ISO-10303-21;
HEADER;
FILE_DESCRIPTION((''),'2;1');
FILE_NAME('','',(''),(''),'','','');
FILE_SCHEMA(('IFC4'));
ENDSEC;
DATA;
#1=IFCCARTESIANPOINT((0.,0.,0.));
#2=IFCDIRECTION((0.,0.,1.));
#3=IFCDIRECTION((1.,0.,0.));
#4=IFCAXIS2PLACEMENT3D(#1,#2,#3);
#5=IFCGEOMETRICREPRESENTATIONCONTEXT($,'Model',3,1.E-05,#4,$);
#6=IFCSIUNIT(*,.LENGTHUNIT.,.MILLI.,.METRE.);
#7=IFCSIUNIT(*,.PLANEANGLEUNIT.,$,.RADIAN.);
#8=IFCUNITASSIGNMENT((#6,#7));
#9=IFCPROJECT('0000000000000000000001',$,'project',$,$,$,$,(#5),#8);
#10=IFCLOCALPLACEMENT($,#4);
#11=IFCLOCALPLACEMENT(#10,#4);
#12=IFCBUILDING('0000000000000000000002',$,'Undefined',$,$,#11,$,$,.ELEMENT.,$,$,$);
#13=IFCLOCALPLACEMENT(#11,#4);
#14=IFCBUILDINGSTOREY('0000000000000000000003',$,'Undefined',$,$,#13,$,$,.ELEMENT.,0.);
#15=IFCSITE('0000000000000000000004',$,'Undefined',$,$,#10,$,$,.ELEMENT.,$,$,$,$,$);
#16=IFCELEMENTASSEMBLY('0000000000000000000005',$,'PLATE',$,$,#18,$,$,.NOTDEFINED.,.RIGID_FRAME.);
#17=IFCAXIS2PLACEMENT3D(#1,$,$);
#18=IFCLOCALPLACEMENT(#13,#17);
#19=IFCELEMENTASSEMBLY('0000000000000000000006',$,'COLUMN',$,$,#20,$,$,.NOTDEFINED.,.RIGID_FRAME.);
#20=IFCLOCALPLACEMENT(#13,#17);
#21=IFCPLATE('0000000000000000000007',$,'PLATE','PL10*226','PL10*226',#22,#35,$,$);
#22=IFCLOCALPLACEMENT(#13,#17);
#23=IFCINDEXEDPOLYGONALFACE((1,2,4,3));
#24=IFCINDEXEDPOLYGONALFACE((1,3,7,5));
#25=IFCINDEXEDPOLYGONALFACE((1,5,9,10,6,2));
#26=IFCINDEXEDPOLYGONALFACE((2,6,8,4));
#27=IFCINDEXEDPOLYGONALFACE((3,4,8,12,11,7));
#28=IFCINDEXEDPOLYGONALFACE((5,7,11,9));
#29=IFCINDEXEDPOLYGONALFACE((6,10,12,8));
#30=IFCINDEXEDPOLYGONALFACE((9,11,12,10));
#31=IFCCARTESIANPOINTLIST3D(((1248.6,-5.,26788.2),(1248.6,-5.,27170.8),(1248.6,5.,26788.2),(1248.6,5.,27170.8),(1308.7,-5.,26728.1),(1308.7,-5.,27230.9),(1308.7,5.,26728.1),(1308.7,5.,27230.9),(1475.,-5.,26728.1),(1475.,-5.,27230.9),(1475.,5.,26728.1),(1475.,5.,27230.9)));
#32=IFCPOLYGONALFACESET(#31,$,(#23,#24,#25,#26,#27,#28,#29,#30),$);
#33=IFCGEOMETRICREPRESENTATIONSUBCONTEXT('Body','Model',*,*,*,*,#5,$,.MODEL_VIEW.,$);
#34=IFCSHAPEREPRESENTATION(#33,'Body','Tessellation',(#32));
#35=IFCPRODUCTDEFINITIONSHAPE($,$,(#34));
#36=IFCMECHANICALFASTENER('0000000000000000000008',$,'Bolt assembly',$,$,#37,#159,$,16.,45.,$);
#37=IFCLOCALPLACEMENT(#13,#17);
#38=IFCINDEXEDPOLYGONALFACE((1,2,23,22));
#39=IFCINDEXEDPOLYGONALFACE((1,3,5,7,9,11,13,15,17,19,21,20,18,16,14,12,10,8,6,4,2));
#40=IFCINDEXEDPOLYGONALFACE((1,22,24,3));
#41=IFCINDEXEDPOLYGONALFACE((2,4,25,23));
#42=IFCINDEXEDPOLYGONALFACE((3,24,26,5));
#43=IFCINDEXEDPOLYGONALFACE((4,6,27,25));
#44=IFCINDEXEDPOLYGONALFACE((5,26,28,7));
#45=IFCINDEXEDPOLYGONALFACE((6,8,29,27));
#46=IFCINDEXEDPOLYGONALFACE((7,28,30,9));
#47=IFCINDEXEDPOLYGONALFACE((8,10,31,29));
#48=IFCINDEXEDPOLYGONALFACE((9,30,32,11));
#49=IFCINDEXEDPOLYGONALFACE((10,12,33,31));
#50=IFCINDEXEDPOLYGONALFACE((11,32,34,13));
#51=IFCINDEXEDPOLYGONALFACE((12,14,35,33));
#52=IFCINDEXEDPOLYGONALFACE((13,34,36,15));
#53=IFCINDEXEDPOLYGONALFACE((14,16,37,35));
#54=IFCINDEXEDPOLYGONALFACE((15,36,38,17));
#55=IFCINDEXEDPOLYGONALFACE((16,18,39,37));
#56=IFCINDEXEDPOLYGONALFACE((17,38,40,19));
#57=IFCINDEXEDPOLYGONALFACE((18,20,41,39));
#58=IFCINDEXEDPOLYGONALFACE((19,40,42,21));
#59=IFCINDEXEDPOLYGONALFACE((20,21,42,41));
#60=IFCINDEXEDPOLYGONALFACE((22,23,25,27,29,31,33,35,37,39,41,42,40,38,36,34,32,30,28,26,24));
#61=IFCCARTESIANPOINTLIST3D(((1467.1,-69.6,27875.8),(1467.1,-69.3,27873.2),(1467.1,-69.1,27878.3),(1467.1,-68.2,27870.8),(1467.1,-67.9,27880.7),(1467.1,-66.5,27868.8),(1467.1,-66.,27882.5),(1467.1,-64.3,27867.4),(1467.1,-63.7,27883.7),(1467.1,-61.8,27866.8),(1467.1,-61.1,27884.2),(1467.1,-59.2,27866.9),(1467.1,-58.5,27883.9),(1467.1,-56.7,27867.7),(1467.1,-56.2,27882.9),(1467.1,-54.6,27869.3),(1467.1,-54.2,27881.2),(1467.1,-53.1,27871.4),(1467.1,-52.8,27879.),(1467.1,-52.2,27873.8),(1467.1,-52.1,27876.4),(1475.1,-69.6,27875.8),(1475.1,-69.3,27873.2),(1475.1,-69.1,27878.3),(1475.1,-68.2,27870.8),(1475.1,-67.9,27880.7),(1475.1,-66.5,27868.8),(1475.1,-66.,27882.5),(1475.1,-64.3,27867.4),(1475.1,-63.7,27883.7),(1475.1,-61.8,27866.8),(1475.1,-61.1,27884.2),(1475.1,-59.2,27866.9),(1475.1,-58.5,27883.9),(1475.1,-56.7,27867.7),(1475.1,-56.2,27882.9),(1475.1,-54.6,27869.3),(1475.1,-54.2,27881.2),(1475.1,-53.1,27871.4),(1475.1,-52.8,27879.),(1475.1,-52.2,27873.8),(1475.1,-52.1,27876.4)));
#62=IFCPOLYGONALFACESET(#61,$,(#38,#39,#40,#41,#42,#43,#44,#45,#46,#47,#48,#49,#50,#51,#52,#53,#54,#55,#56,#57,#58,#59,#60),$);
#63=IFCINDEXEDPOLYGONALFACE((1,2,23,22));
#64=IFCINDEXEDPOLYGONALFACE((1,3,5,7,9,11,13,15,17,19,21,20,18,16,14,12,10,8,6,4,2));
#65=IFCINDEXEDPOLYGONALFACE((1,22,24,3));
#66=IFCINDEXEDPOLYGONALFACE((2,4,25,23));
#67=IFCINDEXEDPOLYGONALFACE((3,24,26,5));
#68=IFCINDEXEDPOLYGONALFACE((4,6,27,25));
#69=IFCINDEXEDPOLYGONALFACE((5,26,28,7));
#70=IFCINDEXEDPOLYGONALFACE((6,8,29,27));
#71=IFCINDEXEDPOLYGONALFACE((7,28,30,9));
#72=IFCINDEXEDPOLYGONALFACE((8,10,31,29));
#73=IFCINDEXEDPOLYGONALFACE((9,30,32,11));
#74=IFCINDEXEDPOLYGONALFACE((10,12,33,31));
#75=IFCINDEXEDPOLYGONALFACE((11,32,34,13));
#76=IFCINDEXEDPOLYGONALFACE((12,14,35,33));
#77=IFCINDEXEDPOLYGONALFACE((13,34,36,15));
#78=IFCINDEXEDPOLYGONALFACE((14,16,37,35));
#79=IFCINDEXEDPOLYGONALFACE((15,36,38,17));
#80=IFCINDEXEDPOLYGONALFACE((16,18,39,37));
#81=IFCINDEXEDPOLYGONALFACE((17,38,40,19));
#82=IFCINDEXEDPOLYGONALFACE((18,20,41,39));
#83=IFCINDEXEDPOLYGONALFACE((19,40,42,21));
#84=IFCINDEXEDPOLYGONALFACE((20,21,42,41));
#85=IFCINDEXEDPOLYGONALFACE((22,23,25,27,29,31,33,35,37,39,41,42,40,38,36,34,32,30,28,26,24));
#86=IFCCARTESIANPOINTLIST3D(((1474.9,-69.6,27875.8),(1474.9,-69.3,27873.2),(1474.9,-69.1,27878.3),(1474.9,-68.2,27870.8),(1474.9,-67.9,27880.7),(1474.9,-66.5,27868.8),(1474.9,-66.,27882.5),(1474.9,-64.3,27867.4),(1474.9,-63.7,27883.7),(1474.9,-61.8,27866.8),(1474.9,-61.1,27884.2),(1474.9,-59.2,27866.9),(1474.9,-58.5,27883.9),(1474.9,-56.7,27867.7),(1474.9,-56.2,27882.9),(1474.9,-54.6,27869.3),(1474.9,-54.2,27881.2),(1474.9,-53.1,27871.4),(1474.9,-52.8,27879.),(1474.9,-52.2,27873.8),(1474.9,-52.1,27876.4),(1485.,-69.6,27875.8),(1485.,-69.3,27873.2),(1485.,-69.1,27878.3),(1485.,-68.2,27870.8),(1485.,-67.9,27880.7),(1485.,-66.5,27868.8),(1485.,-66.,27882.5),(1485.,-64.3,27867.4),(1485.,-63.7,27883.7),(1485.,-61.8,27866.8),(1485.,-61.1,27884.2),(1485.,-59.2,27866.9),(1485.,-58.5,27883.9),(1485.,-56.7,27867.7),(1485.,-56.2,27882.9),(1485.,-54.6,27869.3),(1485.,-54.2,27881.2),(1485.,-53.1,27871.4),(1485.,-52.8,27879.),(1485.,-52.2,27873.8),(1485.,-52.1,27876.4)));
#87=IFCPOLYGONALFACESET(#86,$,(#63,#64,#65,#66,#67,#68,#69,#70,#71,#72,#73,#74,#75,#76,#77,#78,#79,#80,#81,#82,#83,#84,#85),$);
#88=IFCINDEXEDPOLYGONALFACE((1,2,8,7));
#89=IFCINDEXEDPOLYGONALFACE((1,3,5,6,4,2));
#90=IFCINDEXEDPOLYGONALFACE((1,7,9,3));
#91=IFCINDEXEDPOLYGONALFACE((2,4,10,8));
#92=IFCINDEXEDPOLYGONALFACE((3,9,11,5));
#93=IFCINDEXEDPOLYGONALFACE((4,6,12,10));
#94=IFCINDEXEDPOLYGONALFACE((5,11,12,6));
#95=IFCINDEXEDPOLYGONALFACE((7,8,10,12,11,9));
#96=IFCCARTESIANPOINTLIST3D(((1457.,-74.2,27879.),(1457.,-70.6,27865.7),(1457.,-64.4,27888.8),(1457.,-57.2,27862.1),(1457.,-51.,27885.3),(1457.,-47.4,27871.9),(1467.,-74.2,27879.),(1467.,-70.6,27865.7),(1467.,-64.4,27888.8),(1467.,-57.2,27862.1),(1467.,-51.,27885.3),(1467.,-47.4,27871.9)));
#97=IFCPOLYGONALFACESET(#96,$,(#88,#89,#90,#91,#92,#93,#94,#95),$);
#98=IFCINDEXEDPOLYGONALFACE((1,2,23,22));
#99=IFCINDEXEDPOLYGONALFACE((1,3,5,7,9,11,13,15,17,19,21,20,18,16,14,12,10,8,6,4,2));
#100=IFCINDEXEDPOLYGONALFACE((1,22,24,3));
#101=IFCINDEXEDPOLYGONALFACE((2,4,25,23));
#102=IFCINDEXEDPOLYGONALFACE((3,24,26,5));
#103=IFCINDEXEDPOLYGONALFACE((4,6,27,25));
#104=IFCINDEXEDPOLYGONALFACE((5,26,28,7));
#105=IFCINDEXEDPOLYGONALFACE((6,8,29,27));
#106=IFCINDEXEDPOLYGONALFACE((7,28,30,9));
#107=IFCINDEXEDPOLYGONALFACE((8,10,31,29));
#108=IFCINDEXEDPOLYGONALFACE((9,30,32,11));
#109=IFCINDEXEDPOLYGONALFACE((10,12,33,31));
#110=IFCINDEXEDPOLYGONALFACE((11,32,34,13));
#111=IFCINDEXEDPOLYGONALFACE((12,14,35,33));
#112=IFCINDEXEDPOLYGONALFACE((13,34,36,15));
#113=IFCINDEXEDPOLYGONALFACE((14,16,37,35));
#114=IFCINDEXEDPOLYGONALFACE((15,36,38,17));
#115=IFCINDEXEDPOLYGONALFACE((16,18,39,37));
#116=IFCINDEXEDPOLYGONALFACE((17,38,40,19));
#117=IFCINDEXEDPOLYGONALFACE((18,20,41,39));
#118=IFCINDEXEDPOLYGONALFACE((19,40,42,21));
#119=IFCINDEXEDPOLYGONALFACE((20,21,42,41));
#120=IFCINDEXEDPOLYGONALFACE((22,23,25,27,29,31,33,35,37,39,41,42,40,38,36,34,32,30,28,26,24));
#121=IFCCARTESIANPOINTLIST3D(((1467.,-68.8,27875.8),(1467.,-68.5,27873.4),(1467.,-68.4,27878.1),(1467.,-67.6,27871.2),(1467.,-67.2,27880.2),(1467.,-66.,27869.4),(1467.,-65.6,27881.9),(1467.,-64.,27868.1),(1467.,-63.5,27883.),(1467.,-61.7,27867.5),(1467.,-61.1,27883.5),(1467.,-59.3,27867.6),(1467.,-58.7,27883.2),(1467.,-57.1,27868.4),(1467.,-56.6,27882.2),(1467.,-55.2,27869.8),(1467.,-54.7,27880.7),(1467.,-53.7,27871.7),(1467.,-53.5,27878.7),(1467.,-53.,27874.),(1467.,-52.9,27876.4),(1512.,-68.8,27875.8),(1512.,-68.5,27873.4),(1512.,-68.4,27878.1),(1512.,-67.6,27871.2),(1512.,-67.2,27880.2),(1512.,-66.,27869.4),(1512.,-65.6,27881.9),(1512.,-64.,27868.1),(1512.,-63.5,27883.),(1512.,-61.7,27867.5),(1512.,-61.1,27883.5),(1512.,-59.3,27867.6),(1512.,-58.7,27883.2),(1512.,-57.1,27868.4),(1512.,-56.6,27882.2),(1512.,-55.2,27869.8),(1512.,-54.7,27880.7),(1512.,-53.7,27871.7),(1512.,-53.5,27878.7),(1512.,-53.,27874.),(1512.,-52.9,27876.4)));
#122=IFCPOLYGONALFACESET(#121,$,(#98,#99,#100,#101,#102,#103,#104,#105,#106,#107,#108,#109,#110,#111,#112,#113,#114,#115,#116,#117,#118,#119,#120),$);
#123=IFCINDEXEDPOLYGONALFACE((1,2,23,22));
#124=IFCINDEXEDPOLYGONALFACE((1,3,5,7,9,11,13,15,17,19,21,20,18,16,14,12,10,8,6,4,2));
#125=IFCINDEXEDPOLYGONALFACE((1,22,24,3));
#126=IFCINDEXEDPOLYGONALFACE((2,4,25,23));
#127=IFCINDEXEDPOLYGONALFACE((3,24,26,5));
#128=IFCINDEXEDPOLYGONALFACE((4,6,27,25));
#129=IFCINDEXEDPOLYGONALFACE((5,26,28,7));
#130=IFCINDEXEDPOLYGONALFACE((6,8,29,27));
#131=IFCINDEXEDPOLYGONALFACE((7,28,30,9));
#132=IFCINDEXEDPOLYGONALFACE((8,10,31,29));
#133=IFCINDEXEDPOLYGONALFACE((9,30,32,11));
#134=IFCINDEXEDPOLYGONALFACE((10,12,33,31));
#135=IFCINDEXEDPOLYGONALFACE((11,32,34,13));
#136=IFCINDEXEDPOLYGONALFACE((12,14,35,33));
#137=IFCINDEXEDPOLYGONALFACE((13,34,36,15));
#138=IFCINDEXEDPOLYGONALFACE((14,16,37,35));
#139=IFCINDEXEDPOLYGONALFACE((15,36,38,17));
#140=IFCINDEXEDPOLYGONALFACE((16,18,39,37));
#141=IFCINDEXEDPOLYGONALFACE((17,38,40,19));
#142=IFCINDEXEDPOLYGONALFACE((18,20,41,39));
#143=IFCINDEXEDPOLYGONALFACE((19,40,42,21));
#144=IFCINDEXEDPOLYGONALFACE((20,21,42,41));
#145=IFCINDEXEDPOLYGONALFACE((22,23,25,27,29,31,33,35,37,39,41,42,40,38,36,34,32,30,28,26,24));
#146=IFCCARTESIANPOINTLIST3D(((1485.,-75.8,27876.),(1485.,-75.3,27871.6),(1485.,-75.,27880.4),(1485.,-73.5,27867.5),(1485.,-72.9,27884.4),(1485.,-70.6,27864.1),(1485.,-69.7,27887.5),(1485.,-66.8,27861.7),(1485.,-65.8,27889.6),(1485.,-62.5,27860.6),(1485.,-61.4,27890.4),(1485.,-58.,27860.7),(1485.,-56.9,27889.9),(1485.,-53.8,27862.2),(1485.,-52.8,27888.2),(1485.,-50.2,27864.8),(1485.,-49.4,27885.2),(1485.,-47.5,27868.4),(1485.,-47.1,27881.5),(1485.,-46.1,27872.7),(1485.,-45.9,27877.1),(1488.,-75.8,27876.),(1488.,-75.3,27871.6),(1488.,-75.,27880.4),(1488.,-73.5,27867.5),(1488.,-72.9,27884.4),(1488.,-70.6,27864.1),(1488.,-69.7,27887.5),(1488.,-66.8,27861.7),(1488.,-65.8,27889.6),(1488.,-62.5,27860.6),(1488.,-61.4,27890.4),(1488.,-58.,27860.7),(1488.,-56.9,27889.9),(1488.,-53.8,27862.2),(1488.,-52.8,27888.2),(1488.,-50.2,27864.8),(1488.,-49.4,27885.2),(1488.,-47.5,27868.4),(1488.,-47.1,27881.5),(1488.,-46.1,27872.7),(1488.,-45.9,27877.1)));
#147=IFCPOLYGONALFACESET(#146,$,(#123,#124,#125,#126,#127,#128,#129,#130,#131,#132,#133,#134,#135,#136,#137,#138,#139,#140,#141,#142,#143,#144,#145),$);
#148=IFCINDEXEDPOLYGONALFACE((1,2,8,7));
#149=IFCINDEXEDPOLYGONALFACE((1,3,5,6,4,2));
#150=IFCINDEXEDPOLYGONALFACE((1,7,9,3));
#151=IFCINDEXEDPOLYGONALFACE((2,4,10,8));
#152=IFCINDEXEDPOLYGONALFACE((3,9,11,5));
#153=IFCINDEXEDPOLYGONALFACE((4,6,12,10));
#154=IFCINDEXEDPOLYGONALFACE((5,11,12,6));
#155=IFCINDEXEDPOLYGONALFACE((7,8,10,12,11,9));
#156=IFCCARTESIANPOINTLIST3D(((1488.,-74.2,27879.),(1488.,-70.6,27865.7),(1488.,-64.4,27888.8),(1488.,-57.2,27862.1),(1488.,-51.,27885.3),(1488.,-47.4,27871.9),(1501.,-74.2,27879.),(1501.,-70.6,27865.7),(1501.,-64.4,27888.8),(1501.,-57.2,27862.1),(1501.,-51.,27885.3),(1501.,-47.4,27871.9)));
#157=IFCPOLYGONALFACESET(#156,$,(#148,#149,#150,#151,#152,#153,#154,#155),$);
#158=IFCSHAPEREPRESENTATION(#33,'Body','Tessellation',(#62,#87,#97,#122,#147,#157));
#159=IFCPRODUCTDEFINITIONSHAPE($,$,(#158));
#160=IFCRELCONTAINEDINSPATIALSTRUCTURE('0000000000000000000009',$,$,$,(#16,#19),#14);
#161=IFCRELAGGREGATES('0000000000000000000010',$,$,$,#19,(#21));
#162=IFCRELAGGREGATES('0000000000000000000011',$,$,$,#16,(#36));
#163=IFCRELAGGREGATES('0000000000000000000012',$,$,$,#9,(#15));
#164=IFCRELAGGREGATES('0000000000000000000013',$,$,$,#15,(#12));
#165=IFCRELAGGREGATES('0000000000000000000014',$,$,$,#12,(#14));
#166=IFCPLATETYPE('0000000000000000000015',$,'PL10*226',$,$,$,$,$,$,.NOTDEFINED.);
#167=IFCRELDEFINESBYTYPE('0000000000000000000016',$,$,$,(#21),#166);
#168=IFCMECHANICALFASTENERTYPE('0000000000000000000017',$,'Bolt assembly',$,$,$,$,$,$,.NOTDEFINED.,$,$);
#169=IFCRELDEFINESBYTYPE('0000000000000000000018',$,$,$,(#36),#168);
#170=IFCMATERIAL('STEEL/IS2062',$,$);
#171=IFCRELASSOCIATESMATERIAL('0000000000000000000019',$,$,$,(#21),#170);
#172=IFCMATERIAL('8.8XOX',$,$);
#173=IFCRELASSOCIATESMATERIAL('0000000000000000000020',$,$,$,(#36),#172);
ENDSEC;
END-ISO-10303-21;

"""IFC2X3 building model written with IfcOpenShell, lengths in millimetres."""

from ifc_helpers import new_model, si_unit, frame, origin_with_axes, origin_2d_with_axis, place, context, subcontext, project, spatial, polyline, circle, outline, extrude, source, transform, mapped, material, type_object, element, aggregate, save


model = new_model("IFC2X3")

# Units and contexts
model_context = context("Model", 3, precision=1e-05, world=origin_with_axes())
body_context = subcontext(model_context, "Body", "Model", "MODEL_VIEW")
ifc_project = project(units=[si_unit("LENGTHUNIT", "METRE", prefix="MILLI"), si_unit("PLANEANGLEUNIT", "RADIAN")], contexts=[model_context])

# Site, building, storey
site_placement = place(None, origin_with_axes())
site = spatial("IfcSite", under=ifc_project, at=site_placement, Name="Undefined", CompositionType="ELEMENT")
building_placement = place(site_placement, origin_with_axes())
building = spatial("IfcBuilding", under=site, at=building_placement, Name="Undefined", CompositionType="ELEMENT")
storey_placement = place(building_placement, origin_with_axes())
storey = spatial("IfcBuildingStorey", under=building, at=storey_placement, Name="Undefined", CompositionType="ELEMENT", Elevation=0.0)

# Shared definitions
ifc_material_1 = material(Name="STEEL/IS2062")

# Element assembly
assembly_1_placement = place(storey_placement, origin_with_axes())
assembly_1 = element("IfcElementAssembly", 1, at=assembly_1_placement, inside=storey, Name="PLATE", AssemblyPlace="NOTDEFINED", PredefinedType="RIGID_FRAME")

# Element assembly, plate
assembly_2_placement = place(storey_placement, origin_with_axes())
assembly_2 = element("IfcElementAssembly", 2, at=assembly_2_placement, inside=storey, Name="COLUMN", AssemblyPlace="NOTDEFINED", PredefinedType="RIGID_FRAME")
plate_type_1 = type_object("IfcPlateType", Name="PL10*226", PredefinedType="NOTDEFINED")
plate_1_placement = place(assembly_2_placement, frame((1475.0, 0.0, 27230.9), z_axis=(0.0, 1.0, 0.0), x_axis=(0.0, 0.0, -1.0)))
plate_1 = element("IfcPlate", 3, at=plate_1_placement, type_object=plate_type_1, material=ifc_material_1, Name="PLATE", Description="PL10*226", ObjectType="PL10*226", context=body_context, shape_type="SweptSolid", body=[
    extrude(outline(polyline([(0.0, 0.0), (502.8, 0.0), (502.8, 166.3), (442.7, 226.4), (60.1, 226.4), (0.0, 166.3), (0.0, 0.0)])), frame((0.0, 0.0, -5.0), z_axis=(0.0, 0.0, 1.0), x_axis=(1.0, 0.0, 0.0)), (0.0, 0.0, 1.0), 10.0),
])
aggregate(assembly_2, [plate_1])

# Mechanical fastener
ifc_material_2 = material(Name="8.8XOX")
mechanical_fastener_type = type_object("IfcMechanicalFastenerType", Name="Bolt assembly")
shared_shape = source(origin_with_axes(), body_context, "Body", "SweptSolid", [
    extrude(circle(Radius=8.8, at=origin_2d_with_axis()), frame((0.0, 7.1, 0.0), z_axis=(0.0, 1.0, 0.0), x_axis=(1.0, 0.0, 0.0)), (0.0, 0.0, 1.0), 8.0),
    extrude(circle(Radius=8.8, at=origin_2d_with_axis()), frame((0.0, 14.9, 0.0), z_axis=(0.0, 1.0, 0.0), x_axis=(1.0, 0.0, 0.0)), (0.0, 0.0, 1.0), 10.1),
    extrude(outline(polyline([(12.0, -6.9), (12.0, 6.9), (0.0, 13.9), (-12.0, 6.9), (-12.0, -6.9), (0.0, -13.9), (12.0, -6.9)])), frame((0.0, -3.0, 0.0), z_axis=(0.0, 1.0, 0.0), x_axis=(1.0, 0.0, 0.0)), (0.0, 0.0, 1.0), 10.0),
    extrude(circle(Radius=8.0, at=origin_2d_with_axis()), frame((0.0, 7.0, 0.0), z_axis=(0.0, 1.0, 0.0), x_axis=(1.0, 0.0, 0.0)), (0.0, 0.0, 1.0), 45.0),
    extrude(circle(Radius=15.0, at=origin_2d_with_axis()), frame((0.0, 25.0, 0.0), z_axis=(0.0, 1.0, 0.0), x_axis=(1.0, 0.0, 0.0)), (0.0, 0.0, 1.0), 3.0),
    extrude(outline(polyline([(12.0, -6.9), (12.0, 6.9), (0.0, 13.9), (-12.0, 6.9), (-12.0, -6.9), (0.0, -13.9), (12.0, -6.9)])), frame((0.0, 28.0, 0.0), z_axis=(0.0, 1.0, 0.0), x_axis=(1.0, 0.0, 0.0)), (0.0, 0.0, 1.0), 13.0),
])
mechanical_fastener_1_placement = place(assembly_1_placement, frame((1460.0, -60.8, 27875.5), z_axis=(0.0, -0.707107, -0.707107), x_axis=(0.0, 0.707107, -0.707107)))
mechanical_fastener_1 = element("IfcMechanicalFastener", 4, at=mechanical_fastener_1_placement, type_object=mechanical_fastener_type, material=ifc_material_2, Name="Bolt assembly", NominalDiameter=16.0, NominalLength=45.0, context=body_context, shape_type="MappedRepresentation", body=[
    mapped(shared_shape, transform((0.0, 0.0, 0.0))),
])
aggregate(assembly_1, [mechanical_fastener_1])

save(model, "model.ifc")
